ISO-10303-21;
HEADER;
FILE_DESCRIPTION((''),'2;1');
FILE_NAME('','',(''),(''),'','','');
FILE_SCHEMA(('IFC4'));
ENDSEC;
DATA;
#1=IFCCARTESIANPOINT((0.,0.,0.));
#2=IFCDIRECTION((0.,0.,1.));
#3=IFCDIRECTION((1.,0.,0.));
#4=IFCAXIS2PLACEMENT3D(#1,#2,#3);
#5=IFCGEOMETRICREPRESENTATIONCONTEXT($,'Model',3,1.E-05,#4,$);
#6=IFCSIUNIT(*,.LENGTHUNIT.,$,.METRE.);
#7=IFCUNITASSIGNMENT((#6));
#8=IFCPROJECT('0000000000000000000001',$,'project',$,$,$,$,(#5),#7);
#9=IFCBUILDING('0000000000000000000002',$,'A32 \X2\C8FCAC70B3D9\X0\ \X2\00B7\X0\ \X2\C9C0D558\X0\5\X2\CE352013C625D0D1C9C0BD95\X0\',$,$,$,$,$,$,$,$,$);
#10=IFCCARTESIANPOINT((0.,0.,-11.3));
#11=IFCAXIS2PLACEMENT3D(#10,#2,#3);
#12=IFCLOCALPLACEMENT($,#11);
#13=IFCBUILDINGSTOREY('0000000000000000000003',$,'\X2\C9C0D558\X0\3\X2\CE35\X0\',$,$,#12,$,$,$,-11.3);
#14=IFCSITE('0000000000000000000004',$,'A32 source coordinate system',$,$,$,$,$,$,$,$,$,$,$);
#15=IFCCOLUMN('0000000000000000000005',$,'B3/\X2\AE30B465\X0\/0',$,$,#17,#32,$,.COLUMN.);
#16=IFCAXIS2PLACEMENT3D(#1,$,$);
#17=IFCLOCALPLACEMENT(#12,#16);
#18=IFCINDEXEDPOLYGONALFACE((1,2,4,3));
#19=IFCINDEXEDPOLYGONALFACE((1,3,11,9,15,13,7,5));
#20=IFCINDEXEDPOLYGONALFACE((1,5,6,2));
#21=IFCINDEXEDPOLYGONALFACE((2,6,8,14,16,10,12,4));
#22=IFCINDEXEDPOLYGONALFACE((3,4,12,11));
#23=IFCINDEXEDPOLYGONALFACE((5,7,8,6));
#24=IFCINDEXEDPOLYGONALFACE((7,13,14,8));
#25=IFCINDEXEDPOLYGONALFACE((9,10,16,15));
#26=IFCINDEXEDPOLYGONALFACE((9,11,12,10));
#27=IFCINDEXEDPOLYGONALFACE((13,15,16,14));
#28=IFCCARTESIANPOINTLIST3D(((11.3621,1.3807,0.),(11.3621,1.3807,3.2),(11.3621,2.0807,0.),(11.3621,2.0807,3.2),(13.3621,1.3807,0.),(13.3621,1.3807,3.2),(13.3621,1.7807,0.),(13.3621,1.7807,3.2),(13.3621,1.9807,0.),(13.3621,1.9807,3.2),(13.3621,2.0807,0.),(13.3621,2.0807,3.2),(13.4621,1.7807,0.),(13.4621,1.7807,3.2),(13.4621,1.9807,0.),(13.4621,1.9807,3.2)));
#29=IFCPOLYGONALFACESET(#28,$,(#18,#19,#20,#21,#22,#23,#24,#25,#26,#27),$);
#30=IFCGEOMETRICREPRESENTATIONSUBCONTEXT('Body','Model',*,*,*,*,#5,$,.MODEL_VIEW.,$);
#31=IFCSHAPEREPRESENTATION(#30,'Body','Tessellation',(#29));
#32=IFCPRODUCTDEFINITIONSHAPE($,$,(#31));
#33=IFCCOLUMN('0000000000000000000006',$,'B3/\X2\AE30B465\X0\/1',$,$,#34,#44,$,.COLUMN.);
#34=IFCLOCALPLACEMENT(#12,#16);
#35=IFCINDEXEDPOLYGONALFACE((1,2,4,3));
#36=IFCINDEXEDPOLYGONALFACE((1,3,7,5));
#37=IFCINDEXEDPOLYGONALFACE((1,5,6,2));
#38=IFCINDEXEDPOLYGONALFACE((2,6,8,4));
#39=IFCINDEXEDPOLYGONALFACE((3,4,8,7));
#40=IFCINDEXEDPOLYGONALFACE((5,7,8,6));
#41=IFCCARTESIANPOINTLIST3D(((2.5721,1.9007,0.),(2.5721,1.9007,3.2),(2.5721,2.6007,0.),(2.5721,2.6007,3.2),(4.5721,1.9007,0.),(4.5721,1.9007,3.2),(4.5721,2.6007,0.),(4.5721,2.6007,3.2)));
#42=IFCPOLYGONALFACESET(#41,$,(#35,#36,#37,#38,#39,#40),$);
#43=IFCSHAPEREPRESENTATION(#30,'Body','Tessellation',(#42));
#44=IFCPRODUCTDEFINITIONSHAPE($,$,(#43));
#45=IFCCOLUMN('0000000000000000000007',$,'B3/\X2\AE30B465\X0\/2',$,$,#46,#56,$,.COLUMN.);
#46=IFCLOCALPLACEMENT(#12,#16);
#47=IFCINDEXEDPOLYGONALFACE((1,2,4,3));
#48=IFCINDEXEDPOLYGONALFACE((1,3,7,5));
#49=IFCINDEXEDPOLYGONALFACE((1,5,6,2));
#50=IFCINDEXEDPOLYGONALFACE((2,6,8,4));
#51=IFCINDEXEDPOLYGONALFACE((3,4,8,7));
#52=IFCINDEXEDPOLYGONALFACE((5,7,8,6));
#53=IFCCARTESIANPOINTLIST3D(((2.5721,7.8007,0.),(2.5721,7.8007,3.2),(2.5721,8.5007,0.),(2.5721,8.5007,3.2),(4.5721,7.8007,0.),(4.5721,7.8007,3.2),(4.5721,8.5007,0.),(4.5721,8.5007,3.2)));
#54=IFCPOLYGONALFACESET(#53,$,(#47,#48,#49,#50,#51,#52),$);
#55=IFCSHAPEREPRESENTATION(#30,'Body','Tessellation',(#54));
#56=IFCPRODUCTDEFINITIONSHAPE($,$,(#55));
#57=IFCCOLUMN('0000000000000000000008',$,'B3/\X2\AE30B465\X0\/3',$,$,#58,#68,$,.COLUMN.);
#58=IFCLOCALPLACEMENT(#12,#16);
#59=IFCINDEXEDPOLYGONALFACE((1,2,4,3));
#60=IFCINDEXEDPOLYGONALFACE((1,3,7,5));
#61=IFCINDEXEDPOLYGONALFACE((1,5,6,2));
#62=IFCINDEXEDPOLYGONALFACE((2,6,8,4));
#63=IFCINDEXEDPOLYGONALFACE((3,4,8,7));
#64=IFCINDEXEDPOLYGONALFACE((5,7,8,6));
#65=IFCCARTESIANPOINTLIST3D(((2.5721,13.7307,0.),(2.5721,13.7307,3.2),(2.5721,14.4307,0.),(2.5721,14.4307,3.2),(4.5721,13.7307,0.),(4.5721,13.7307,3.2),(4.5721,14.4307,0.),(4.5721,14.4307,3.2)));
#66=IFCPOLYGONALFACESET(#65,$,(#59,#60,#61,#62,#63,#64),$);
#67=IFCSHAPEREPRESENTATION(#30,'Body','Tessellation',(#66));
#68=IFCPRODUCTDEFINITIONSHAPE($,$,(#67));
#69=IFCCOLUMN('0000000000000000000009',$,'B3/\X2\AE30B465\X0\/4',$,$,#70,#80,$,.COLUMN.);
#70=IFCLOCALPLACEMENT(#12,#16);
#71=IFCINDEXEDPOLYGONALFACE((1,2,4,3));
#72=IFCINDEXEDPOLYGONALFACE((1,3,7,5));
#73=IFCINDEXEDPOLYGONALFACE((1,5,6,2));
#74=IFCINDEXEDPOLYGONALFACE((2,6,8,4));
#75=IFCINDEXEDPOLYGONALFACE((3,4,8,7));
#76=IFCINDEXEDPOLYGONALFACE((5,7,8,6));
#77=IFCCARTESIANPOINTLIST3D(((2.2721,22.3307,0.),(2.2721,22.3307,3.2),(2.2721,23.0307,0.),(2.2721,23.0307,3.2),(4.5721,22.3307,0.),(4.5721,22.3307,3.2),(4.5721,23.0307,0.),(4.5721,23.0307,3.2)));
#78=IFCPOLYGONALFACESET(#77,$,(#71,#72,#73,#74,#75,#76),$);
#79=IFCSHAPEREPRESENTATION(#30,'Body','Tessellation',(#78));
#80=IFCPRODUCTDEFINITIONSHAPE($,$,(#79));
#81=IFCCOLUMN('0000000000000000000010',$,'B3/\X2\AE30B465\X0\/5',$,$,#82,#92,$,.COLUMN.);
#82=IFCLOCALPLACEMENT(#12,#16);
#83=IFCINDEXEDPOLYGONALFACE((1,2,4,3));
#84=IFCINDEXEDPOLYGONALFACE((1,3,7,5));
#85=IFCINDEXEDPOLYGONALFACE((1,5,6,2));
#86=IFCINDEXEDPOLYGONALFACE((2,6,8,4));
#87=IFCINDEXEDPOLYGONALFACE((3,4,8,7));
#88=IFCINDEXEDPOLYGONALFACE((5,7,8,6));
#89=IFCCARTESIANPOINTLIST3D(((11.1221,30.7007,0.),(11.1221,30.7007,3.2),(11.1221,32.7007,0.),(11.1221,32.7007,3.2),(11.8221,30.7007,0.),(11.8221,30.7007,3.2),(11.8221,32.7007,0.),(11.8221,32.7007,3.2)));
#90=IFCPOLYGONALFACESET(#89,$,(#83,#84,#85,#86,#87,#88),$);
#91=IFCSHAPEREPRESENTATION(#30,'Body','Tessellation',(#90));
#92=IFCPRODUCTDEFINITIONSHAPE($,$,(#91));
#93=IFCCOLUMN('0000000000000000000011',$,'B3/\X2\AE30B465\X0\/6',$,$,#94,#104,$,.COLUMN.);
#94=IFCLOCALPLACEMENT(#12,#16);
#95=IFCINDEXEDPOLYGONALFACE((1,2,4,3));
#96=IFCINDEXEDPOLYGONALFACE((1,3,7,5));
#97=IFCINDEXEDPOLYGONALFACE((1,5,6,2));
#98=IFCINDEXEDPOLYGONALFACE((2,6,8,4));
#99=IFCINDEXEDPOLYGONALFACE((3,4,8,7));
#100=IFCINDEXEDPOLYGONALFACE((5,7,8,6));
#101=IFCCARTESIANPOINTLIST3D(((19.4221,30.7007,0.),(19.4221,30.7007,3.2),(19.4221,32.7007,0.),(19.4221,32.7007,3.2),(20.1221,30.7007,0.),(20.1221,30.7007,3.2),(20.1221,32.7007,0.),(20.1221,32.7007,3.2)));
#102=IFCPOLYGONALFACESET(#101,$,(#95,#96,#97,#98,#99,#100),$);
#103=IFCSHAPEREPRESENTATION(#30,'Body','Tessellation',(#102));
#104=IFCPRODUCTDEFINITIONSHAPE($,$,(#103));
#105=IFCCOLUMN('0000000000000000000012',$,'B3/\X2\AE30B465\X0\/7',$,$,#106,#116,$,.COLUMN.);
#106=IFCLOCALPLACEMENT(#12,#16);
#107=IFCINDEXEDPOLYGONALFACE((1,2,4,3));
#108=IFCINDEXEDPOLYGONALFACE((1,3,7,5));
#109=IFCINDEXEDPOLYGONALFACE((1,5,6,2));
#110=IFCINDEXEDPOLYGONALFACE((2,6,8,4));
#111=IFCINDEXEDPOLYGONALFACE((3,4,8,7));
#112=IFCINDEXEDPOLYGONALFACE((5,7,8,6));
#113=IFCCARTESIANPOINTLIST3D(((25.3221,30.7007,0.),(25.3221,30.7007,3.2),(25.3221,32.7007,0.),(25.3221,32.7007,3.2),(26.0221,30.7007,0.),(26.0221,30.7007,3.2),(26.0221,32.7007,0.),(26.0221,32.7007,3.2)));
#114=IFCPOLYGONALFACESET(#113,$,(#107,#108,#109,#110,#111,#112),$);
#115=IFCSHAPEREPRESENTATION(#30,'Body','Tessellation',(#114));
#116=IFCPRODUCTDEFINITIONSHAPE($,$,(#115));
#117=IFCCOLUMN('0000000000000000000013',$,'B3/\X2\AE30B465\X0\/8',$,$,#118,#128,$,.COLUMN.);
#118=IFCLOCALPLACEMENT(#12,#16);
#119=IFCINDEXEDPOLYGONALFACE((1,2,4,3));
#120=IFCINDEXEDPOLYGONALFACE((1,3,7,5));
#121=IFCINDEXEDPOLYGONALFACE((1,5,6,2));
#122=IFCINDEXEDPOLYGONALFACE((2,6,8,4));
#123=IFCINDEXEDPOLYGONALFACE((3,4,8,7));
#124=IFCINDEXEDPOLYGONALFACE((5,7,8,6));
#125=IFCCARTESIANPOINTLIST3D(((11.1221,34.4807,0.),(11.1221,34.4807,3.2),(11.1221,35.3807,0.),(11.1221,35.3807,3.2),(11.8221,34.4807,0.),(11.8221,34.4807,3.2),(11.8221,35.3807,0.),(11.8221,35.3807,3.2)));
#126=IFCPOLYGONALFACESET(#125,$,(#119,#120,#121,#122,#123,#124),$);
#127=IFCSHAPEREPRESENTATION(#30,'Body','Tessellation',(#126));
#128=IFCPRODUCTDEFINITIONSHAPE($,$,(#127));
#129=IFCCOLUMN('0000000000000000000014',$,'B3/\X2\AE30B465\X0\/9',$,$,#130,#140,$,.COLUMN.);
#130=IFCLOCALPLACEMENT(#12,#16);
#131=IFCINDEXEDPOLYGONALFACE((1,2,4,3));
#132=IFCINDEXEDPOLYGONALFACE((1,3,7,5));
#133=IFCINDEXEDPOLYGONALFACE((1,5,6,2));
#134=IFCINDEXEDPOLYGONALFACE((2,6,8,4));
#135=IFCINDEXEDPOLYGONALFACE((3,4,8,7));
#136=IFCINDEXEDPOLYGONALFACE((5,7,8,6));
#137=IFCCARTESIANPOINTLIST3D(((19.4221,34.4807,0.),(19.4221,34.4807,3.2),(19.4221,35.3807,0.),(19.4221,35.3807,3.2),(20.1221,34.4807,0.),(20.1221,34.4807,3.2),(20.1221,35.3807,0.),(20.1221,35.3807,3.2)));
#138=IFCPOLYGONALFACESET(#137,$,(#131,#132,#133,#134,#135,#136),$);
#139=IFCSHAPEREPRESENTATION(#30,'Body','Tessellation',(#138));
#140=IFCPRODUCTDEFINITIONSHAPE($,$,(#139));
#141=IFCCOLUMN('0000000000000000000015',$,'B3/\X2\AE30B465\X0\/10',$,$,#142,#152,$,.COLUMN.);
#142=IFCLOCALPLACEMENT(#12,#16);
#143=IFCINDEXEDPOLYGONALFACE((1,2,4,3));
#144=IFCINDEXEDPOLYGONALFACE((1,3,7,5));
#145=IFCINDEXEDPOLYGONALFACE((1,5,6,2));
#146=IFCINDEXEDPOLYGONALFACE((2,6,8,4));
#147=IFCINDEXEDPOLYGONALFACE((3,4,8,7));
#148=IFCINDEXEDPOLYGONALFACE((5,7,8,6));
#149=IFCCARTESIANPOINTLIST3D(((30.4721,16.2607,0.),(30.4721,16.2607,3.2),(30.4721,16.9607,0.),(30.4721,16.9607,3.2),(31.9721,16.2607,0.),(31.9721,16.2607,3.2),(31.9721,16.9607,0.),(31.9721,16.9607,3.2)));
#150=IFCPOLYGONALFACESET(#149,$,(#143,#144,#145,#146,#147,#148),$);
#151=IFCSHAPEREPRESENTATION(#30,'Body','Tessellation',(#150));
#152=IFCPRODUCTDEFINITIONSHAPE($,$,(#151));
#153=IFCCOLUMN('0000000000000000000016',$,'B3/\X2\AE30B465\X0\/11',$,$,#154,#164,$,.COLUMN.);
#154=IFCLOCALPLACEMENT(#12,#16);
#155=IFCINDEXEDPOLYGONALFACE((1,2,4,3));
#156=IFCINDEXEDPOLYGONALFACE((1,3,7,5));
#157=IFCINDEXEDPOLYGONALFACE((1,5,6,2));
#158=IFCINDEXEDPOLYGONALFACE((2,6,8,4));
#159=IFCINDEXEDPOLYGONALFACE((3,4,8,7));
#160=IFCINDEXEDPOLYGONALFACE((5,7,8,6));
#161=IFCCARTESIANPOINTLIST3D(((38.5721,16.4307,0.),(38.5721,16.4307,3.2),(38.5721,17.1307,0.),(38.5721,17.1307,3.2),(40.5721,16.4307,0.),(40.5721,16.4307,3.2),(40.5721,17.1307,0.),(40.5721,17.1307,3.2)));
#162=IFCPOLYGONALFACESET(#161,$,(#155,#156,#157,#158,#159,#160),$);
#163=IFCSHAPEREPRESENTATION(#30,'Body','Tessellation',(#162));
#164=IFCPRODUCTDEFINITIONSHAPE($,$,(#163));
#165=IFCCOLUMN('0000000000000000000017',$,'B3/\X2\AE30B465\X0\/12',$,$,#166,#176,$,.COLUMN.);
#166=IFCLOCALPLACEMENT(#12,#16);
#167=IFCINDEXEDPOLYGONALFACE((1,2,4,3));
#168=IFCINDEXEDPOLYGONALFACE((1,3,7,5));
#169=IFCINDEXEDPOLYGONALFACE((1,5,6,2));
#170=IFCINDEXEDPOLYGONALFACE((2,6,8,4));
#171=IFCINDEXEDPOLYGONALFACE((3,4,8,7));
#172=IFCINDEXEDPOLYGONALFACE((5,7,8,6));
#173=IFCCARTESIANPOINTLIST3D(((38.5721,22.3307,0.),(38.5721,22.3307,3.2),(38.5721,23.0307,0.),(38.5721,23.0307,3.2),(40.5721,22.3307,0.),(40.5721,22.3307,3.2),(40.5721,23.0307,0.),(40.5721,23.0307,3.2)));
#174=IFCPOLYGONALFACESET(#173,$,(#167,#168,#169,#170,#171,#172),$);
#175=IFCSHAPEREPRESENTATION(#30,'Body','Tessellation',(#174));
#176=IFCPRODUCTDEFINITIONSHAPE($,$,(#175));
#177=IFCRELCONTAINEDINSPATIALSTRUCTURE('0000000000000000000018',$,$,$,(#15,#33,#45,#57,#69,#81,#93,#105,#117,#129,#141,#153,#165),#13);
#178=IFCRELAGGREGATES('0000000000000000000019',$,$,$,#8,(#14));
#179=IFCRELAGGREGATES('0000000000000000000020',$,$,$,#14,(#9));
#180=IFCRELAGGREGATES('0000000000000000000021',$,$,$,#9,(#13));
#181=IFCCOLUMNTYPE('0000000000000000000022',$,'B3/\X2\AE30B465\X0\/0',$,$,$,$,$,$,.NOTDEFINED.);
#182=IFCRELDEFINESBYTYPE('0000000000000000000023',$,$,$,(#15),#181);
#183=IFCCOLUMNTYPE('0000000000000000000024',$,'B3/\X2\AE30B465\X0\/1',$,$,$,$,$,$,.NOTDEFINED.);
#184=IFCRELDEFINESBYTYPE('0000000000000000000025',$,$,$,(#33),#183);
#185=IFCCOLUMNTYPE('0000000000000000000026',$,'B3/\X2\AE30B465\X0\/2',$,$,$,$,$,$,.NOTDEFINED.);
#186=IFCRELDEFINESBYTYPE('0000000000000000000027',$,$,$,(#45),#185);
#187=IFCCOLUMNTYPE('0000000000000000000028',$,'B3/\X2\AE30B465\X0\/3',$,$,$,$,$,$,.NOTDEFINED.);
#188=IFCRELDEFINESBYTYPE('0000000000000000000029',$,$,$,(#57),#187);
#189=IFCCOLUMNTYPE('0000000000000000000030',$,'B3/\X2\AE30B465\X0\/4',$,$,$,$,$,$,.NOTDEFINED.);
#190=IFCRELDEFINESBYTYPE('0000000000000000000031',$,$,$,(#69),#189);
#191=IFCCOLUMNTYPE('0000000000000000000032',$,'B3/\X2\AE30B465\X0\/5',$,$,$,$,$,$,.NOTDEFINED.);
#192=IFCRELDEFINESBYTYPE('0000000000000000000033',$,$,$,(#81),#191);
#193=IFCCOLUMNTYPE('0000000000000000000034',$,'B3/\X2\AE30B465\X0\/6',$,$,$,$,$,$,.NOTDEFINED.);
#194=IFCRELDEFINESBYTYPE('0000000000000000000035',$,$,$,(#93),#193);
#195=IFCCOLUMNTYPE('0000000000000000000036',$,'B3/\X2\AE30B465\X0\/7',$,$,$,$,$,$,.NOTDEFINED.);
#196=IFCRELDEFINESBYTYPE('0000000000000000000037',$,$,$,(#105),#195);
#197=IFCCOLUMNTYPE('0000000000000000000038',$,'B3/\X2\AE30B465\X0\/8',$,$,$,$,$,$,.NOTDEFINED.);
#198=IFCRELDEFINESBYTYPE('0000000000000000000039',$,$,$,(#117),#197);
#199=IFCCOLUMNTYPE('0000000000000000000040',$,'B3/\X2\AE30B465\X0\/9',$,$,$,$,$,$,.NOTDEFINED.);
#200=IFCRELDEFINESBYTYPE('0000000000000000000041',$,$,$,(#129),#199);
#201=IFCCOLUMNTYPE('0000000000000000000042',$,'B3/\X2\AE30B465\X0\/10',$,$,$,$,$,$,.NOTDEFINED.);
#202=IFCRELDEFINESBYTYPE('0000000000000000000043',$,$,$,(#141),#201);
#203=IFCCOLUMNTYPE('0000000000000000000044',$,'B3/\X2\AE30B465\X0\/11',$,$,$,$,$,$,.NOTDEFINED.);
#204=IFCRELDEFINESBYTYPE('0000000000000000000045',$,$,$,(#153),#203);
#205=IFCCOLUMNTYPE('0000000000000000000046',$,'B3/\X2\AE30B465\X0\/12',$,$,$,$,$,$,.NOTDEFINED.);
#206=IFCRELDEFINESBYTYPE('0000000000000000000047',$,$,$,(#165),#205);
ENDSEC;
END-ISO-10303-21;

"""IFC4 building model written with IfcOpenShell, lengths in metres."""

from ifc_helpers import new_model, si_unit, frame, origin, origin_with_axes, place, context, subcontext, project, spatial, polyline, outline, extrude, source, transform, mapped, type_object, type_shapes, element, save


model = new_model("IFC4")

# Units and contexts
model_context = context("Model", 3, precision=1e-05, world=origin_with_axes())
body_context = subcontext(model_context, "Body", "Model", "MODEL_VIEW")
ifc_project = project(units=[si_unit("LENGTHUNIT", "METRE")], contexts=[model_context])

# Site, building, storey
site = spatial("IfcSite", under=ifc_project, Name="A32 source coordinate system")
building = spatial("IfcBuilding", under=site, Name="A32 주거동 · 지하5층–옥탑지붕")
storey_placement = place(None, frame((0.0, 0.0, -11.3), z_axis=(0.0, 0.0, 1.0), x_axis=(1.0, 0.0, 0.0)))
storey = spatial("IfcBuildingStorey", under=building, at=storey_placement, Name="지하3층", Elevation=-11.3)

# Columns
column_type_1 = type_object("IfcColumnType", Name="B3/기둥/0", PredefinedType="NOTDEFINED")
shared_shape_1 = source(origin(), body_context, "Body", "SweptSolid", [
    extrude(outline(polyline([(11.3621, 1.3807), (11.3621, 2.0807), (13.3621, 2.0807), (13.3621, 1.9807), (13.4621, 1.9807), (13.4621, 1.7807), (13.3621, 1.7807), (13.3621, 1.3807), (11.3621, 1.3807)])), origin(), (0.0, 0.0, 1.0), 3.2),
])
type_shapes(column_type_1, [shared_shape_1])
column_1_placement = place(storey_placement, origin_with_axes())
element("IfcColumn", 1, at=column_1_placement, inside=storey, type_object=column_type_1, Name="B3/기둥/0", PredefinedType="COLUMN", context=body_context, shape_type="MappedRepresentation", body=[
    mapped(shared_shape_1, transform((0.0, 0.0, 0.0), scale=1.0)),
])
column_type_2 = type_object("IfcColumnType", Name="B3/기둥/1", PredefinedType="NOTDEFINED")
shared_shape_2 = source(origin(), body_context, "Body", "SweptSolid", [
    extrude(outline(polyline([(4.5721, 1.9007), (2.5721, 1.9007), (2.5721, 2.6007), (4.5721, 2.6007), (4.5721, 1.9007)])), origin(), (0.0, 0.0, 1.0), 3.2),
])
type_shapes(column_type_2, [shared_shape_2])
column_2_placement = place(storey_placement, origin_with_axes())
element("IfcColumn", 2, at=column_2_placement, inside=storey, type_object=column_type_2, Name="B3/기둥/1", PredefinedType="COLUMN", context=body_context, shape_type="MappedRepresentation", body=[
    mapped(shared_shape_2, transform((0.0, 0.0, 0.0), scale=1.0)),
])
column_type_3 = type_object("IfcColumnType", Name="B3/기둥/2", PredefinedType="NOTDEFINED")
shared_shape_3 = source(origin(), body_context, "Body", "SweptSolid", [
    extrude(outline(polyline([(4.5721, 7.8007), (2.5721, 7.8007), (2.5721, 8.5007), (4.5721, 8.5007), (4.5721, 7.8007)])), origin(), (0.0, 0.0, 1.0), 3.2),
])
type_shapes(column_type_3, [shared_shape_3])
column_3_placement = place(storey_placement, origin_with_axes())
element("IfcColumn", 3, at=column_3_placement, inside=storey, type_object=column_type_3, Name="B3/기둥/2", PredefinedType="COLUMN", context=body_context, shape_type="MappedRepresentation", body=[
    mapped(shared_shape_3, transform((0.0, 0.0, 0.0), scale=1.0)),
])
column_type_4 = type_object("IfcColumnType", Name="B3/기둥/3", PredefinedType="NOTDEFINED")
shared_shape_4 = source(origin(), body_context, "Body", "SweptSolid", [
    extrude(outline(polyline([(4.5721, 14.4307), (4.5721, 13.7307), (2.5721, 13.7307), (2.5721, 14.4307), (4.5721, 14.4307)])), origin(), (0.0, 0.0, 1.0), 3.2),
])
type_shapes(column_type_4, [shared_shape_4])
column_4_placement = place(storey_placement, origin_with_axes())
element("IfcColumn", 4, at=column_4_placement, inside=storey, type_object=column_type_4, Name="B3/기둥/3", PredefinedType="COLUMN", context=body_context, shape_type="MappedRepresentation", body=[
    mapped(shared_shape_4, transform((0.0, 0.0, 0.0), scale=1.0)),
])
column_type_5 = type_object("IfcColumnType", Name="B3/기둥/4", PredefinedType="NOTDEFINED")
shared_shape_5 = source(origin(), body_context, "Body", "SweptSolid", [
    extrude(outline(polyline([(2.2721, 23.0307), (4.5721, 23.0307), (4.5721, 22.3307), (2.2721, 22.3307), (2.2721, 23.0307)])), origin(), (0.0, 0.0, 1.0), 3.2),
])
type_shapes(column_type_5, [shared_shape_5])
column_5_placement = place(storey_placement, origin_with_axes())
element("IfcColumn", 5, at=column_5_placement, inside=storey, type_object=column_type_5, Name="B3/기둥/4", PredefinedType="COLUMN", context=body_context, shape_type="MappedRepresentation", body=[
    mapped(shared_shape_5, transform((0.0, 0.0, 0.0), scale=1.0)),
])
column_type_6 = type_object("IfcColumnType", Name="B3/기둥/5", PredefinedType="NOTDEFINED")
shared_shape_6 = source(origin(), body_context, "Body", "SweptSolid", [
    extrude(outline(polyline([(11.8221, 30.7007), (11.1221, 30.7007), (11.1221, 32.7007), (11.8221, 32.7007), (11.8221, 30.7007)])), origin(), (0.0, 0.0, 1.0), 3.2),
])
type_shapes(column_type_6, [shared_shape_6])
column_6_placement = place(storey_placement, origin_with_axes())
element("IfcColumn", 6, at=column_6_placement, inside=storey, type_object=column_type_6, Name="B3/기둥/5", PredefinedType="COLUMN", context=body_context, shape_type="MappedRepresentation", body=[
    mapped(shared_shape_6, transform((0.0, 0.0, 0.0), scale=1.0)),
])
column_type_7 = type_object("IfcColumnType", Name="B3/기둥/6", PredefinedType="NOTDEFINED")
shared_shape_7 = source(origin(), body_context, "Body", "SweptSolid", [
    extrude(outline(polyline([(20.1221, 30.7007), (19.4221, 30.7007), (19.4221, 32.7007), (20.1221, 32.7007), (20.1221, 30.7007)])), origin(), (0.0, 0.0, 1.0), 3.2),
])
type_shapes(column_type_7, [shared_shape_7])
column_7_placement = place(storey_placement, origin_with_axes())
element("IfcColumn", 7, at=column_7_placement, inside=storey, type_object=column_type_7, Name="B3/기둥/6", PredefinedType="COLUMN", context=body_context, shape_type="MappedRepresentation", body=[
    mapped(shared_shape_7, transform((0.0, 0.0, 0.0), scale=1.0)),
])
column_type_8 = type_object("IfcColumnType", Name="B3/기둥/7", PredefinedType="NOTDEFINED")
shared_shape_8 = source(origin(), body_context, "Body", "SweptSolid", [
    extrude(outline(polyline([(26.0221, 30.7007), (25.3221, 30.7007), (25.3221, 32.7007), (26.0221, 32.7007), (26.0221, 30.7007)])), origin(), (0.0, 0.0, 1.0), 3.2),
])
type_shapes(column_type_8, [shared_shape_8])
column_8_placement = place(storey_placement, origin_with_axes())
element("IfcColumn", 8, at=column_8_placement, inside=storey, type_object=column_type_8, Name="B3/기둥/7", PredefinedType="COLUMN", context=body_context, shape_type="MappedRepresentation", body=[
    mapped(shared_shape_8, transform((0.0, 0.0, 0.0), scale=1.0)),
])
column_type_9 = type_object("IfcColumnType", Name="B3/기둥/8", PredefinedType="NOTDEFINED")
shared_shape_9 = source(origin(), body_context, "Body", "SweptSolid", [
    extrude(outline(polyline([(11.1221, 34.4807), (11.1221, 35.3807), (11.8221, 35.3807), (11.8221, 34.4807), (11.1221, 34.4807)])), origin(), (0.0, 0.0, 1.0), 3.2),
])
type_shapes(column_type_9, [shared_shape_9])
column_9_placement = place(storey_placement, origin_with_axes())
element("IfcColumn", 9, at=column_9_placement, inside=storey, type_object=column_type_9, Name="B3/기둥/8", PredefinedType="COLUMN", context=body_context, shape_type="MappedRepresentation", body=[
    mapped(shared_shape_9, transform((0.0, 0.0, 0.0), scale=1.0)),
])
column_type_10 = type_object("IfcColumnType", Name="B3/기둥/9", PredefinedType="NOTDEFINED")
shared_shape_10 = source(origin(), body_context, "Body", "SweptSolid", [
    extrude(outline(polyline([(20.1221, 35.3807), (20.1221, 34.4807), (19.4221, 34.4807), (19.4221, 35.3807), (20.1221, 35.3807)])), origin(), (0.0, 0.0, 1.0), 3.2),
])
type_shapes(column_type_10, [shared_shape_10])
column_10_placement = place(storey_placement, origin_with_axes())
element("IfcColumn", 10, at=column_10_placement, inside=storey, type_object=column_type_10, Name="B3/기둥/9", PredefinedType="COLUMN", context=body_context, shape_type="MappedRepresentation", body=[
    mapped(shared_shape_10, transform((0.0, 0.0, 0.0), scale=1.0)),
])
column_type_11 = type_object("IfcColumnType", Name="B3/기둥/10", PredefinedType="NOTDEFINED")
shared_shape_11 = source(origin(), body_context, "Body", "SweptSolid", [
    extrude(outline(polyline([(30.4721, 16.9607), (31.9721, 16.9607), (31.9721, 16.2607), (30.4721, 16.2607), (30.4721, 16.9607)])), origin(), (0.0, 0.0, 1.0), 3.2),
])
type_shapes(column_type_11, [shared_shape_11])
column_11_placement = place(storey_placement, origin_with_axes())
element("IfcColumn", 11, at=column_11_placement, inside=storey, type_object=column_type_11, Name="B3/기둥/10", PredefinedType="COLUMN", context=body_context, shape_type="MappedRepresentation", body=[
    mapped(shared_shape_11, transform((0.0, 0.0, 0.0), scale=1.0)),
])
column_type_12 = type_object("IfcColumnType", Name="B3/기둥/11", PredefinedType="NOTDEFINED")
shared_shape_12 = source(origin(), body_context, "Body", "SweptSolid", [
    extrude(outline(polyline([(40.5721, 16.4307), (38.5721, 16.4307), (38.5721, 17.1307), (40.5721, 17.1307), (40.5721, 16.4307)])), origin(), (0.0, 0.0, 1.0), 3.2),
])
type_shapes(column_type_12, [shared_shape_12])
column_12_placement = place(storey_placement, origin_with_axes())
element("IfcColumn", 12, at=column_12_placement, inside=storey, type_object=column_type_12, Name="B3/기둥/11", PredefinedType="COLUMN", context=body_context, shape_type="MappedRepresentation", body=[
    mapped(shared_shape_12, transform((0.0, 0.0, 0.0), scale=1.0)),
])
column_type_13 = type_object("IfcColumnType", Name="B3/기둥/12", PredefinedType="NOTDEFINED")
shared_shape_13 = source(origin(), body_context, "Body", "SweptSolid", [
    extrude(outline(polyline([(40.5721, 22.3307), (38.5721, 22.3307), (38.5721, 23.0307), (40.5721, 23.0307), (40.5721, 22.3307)])), origin(), (0.0, 0.0, 1.0), 3.2),
])
type_shapes(column_type_13, [shared_shape_13])
column_13_placement = place(storey_placement, origin_with_axes())
element("IfcColumn", 13, at=column_13_placement, inside=storey, type_object=column_type_13, Name="B3/기둥/12", PredefinedType="COLUMN", context=body_context, shape_type="MappedRepresentation", body=[
    mapped(shared_shape_13, transform((0.0, 0.0, 0.0), scale=1.0)),
])

save(model, "model.ifc")
